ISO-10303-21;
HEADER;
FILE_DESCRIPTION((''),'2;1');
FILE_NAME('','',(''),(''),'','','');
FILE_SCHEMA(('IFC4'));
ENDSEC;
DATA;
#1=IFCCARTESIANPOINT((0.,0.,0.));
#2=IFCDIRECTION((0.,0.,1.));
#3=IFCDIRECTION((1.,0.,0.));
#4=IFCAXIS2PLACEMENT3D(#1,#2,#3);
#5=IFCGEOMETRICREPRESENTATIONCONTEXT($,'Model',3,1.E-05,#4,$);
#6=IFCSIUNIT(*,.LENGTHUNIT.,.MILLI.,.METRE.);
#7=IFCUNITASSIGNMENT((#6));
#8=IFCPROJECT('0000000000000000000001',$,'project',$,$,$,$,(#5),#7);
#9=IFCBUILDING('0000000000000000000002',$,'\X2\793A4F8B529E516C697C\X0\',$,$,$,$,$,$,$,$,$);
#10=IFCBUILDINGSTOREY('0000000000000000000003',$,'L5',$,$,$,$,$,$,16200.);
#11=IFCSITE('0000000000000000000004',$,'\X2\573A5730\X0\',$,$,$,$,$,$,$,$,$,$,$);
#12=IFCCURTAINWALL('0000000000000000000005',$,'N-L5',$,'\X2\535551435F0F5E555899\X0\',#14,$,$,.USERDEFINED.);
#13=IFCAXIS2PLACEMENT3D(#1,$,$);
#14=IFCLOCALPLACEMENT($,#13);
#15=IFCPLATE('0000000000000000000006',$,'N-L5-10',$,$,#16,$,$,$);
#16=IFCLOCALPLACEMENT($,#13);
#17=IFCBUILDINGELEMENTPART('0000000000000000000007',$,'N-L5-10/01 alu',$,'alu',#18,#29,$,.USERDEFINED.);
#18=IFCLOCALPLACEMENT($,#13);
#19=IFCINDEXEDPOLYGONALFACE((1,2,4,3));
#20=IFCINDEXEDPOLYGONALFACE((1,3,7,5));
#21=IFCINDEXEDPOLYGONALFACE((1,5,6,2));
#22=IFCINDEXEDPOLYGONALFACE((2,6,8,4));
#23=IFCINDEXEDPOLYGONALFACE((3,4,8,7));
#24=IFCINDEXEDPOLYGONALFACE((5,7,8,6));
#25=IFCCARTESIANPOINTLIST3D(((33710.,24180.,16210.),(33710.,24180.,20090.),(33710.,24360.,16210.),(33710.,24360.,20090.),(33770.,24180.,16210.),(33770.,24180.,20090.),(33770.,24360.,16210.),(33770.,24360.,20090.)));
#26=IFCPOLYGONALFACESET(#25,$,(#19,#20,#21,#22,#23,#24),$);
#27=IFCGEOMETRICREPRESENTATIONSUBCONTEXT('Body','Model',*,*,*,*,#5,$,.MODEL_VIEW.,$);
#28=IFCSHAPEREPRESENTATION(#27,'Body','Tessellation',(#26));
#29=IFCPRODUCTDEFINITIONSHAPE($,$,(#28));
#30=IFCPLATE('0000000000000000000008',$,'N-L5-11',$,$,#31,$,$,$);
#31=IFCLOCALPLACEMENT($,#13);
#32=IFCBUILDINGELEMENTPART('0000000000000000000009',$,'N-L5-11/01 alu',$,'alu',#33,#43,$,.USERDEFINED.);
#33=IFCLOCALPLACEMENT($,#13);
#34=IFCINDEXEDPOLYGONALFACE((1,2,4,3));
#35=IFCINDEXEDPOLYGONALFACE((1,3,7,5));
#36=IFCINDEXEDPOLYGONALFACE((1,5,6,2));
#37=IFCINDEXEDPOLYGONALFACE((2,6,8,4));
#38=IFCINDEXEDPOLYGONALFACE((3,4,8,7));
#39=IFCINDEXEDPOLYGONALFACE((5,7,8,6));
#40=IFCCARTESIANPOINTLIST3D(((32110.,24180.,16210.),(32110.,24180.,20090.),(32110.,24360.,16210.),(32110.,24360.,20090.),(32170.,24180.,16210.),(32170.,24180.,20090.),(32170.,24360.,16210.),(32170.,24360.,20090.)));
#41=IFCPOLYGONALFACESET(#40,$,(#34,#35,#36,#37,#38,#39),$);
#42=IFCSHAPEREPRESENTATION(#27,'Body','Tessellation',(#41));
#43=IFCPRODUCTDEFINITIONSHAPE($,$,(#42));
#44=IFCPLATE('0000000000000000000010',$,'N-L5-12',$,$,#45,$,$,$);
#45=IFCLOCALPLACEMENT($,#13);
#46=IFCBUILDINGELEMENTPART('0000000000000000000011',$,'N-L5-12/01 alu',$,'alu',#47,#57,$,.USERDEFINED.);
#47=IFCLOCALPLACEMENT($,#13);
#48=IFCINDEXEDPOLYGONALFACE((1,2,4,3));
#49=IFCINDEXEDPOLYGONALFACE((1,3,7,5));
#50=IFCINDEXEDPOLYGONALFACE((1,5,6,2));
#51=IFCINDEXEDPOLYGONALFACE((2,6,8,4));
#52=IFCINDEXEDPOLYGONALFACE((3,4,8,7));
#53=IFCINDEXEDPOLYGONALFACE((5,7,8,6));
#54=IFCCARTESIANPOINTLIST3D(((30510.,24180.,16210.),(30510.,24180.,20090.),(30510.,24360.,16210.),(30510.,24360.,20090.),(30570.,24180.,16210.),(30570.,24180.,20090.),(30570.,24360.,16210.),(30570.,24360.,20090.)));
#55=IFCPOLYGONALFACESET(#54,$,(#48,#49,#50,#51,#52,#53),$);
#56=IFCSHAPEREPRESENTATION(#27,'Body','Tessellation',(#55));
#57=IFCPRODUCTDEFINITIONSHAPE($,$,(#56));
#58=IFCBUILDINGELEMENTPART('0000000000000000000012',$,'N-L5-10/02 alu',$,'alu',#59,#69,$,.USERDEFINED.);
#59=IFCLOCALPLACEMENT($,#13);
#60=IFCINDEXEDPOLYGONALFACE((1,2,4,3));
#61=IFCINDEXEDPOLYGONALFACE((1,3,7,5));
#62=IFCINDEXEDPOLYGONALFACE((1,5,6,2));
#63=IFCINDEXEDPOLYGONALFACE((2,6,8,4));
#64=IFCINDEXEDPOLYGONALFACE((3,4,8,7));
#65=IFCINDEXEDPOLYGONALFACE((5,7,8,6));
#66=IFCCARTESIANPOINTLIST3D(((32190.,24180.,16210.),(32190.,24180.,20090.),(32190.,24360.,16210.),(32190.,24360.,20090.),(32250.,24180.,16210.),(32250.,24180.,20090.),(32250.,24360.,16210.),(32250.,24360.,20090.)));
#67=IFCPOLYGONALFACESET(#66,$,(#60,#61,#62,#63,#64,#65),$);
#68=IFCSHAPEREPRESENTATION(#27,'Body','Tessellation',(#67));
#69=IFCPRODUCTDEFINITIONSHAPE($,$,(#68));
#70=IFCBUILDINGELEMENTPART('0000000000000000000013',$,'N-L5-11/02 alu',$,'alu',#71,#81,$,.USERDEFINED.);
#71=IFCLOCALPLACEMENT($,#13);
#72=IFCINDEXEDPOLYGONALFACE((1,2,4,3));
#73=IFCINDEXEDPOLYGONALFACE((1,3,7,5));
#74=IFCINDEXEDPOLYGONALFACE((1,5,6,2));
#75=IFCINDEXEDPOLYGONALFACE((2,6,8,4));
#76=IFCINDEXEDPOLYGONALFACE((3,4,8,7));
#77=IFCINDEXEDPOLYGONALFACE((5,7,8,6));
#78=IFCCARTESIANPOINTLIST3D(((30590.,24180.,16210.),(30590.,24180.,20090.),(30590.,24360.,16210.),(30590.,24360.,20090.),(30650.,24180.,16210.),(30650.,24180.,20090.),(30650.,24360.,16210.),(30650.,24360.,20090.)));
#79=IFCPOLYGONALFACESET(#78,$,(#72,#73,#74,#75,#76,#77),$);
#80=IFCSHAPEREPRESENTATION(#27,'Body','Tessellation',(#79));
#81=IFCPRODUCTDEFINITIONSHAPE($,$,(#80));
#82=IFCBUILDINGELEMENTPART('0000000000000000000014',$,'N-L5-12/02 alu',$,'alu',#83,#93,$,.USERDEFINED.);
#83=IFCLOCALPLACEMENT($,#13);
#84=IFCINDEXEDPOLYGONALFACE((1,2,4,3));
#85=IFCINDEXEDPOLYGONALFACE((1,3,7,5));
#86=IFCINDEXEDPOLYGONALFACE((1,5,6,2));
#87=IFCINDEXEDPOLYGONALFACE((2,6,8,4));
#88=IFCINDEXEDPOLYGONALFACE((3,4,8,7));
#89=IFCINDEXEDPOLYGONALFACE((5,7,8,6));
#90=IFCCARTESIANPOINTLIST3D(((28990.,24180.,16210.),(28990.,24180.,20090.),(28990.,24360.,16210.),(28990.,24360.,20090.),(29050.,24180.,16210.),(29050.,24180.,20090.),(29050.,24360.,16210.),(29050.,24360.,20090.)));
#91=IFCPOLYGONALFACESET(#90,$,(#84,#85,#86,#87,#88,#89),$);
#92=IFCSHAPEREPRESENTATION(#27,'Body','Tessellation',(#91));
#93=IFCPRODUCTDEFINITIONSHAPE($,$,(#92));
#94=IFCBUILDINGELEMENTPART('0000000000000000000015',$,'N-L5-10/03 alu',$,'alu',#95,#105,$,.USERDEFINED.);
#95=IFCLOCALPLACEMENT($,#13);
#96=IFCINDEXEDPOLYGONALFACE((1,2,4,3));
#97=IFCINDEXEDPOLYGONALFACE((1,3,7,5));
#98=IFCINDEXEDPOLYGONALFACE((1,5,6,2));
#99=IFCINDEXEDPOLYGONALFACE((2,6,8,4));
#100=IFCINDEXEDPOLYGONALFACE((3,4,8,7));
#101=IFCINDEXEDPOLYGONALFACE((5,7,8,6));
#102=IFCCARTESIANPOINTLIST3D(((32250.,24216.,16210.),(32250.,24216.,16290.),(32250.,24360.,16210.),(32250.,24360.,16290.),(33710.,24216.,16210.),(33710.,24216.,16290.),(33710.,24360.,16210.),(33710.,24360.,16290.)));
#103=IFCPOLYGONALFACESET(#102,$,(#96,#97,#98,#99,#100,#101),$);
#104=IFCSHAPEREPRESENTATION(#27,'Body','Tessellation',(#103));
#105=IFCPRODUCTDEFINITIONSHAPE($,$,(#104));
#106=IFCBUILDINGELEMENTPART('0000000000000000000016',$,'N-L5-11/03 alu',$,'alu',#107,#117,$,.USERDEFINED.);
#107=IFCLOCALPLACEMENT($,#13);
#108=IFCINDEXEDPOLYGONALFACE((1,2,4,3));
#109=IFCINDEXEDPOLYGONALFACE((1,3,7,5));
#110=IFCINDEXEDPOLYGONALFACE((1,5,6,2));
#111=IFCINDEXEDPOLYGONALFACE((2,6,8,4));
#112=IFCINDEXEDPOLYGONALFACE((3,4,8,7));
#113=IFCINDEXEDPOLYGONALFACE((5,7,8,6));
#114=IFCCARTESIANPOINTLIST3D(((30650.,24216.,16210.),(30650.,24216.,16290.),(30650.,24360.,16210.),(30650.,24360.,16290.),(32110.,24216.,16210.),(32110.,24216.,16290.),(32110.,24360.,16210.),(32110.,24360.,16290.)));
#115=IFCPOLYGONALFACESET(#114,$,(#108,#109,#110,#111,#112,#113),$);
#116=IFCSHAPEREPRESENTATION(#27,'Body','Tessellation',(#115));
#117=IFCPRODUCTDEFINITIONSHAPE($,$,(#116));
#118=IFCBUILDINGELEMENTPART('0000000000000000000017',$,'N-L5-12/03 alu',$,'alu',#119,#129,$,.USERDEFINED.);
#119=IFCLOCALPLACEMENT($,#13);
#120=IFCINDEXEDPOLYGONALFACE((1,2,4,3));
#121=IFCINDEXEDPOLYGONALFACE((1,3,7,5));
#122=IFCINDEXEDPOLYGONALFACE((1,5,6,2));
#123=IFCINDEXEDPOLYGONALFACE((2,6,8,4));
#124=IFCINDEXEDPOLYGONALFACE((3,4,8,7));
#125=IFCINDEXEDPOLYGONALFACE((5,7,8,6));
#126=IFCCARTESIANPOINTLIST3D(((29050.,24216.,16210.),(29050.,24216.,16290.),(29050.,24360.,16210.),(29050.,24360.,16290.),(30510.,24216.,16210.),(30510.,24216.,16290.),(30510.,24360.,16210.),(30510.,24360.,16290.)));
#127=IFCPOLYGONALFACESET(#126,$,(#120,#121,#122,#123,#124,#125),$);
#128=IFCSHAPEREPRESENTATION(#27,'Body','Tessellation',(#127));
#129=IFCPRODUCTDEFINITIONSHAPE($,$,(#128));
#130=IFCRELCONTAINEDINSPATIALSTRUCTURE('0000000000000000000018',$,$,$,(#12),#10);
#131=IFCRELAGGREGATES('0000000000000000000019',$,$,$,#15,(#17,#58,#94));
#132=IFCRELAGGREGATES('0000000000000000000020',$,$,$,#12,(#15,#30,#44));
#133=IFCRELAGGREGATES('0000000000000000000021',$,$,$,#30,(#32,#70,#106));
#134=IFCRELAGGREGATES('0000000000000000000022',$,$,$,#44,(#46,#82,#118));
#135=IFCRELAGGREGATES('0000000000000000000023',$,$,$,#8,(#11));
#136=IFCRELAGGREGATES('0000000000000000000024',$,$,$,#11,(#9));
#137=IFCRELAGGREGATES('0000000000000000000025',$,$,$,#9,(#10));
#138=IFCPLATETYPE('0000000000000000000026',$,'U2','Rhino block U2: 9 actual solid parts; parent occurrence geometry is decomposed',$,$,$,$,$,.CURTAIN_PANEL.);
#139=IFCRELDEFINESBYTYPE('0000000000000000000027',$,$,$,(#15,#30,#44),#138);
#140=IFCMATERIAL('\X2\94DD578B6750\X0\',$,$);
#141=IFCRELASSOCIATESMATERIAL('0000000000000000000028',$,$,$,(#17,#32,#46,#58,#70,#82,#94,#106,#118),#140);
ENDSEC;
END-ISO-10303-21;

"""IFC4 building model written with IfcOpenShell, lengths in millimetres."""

from ifc_helpers import new_model, si_unit, frame, frame_2d, origin, origin_with_axes, place, context, subcontext, project, spatial, rectangle, extrude, source, transform, mapped, material, type_object, element, aggregate, save


model = new_model("IFC4")

# Units and contexts
model_context = context("Model", 3, precision=1e-05, world=origin_with_axes())
body_context = subcontext(model_context, "Body", "Model", "MODEL_VIEW")
ifc_project = project(units=[si_unit("LENGTHUNIT", "METRE", prefix="MILLI")], contexts=[model_context])

# Site, building, storey
site = spatial("IfcSite", under=ifc_project, Name="场地")
building = spatial("IfcBuilding", under=site, Name="示例办公楼")
storey = spatial("IfcBuildingStorey", under=building, Name="L5", Elevation=16200.0)

# Curtain wall, plates, building element parts
curtain_wall = element("IfcCurtainWall", 1, inside=storey, Name="N-L5", ObjectType="单元式幕墙", PredefinedType="USERDEFINED")
plate_type = type_object("IfcPlateType", Name="U2", Description="Rhino block U2: 9 actual solid parts; parent occurrence geometry is decomposed", PredefinedType="CURTAIN_PANEL")
plate_1_placement = place(None, frame((33770.0, 24360.0, 16210.0), z_axis=(0.0, 0.0, 1.0), x_axis=(-1.0, 0.0, 0.0)))
plate_1 = element("IfcPlate", 2, at=plate_1_placement, type_object=plate_type, Name="N-L5-10")
ifc_material_1 = material(Name="铝型材")
shared_shape_1 = source(origin(), body_context, "Body", "SweptSolid", [
    extrude(rectangle(XDim=60.0, YDim=180.0, at=frame_2d((30.0, 90.0))), origin(), (0.0, 0.0, 1.0), 3880.0),
])
building_element_part_1_placement = place(plate_1_placement, origin())
building_element_part_1 = element("IfcBuildingElementPart", 3, at=building_element_part_1_placement, material=ifc_material_1, Name="N-L5-10/01 alu", ObjectType="alu", PredefinedType="USERDEFINED", context=body_context, shape_type="MappedRepresentation", body=[
    mapped(shared_shape_1, transform((0.0, 0.0, 0.0))),
])
plate_2_placement = place(None, frame((32170.0, 24360.0, 16210.0), z_axis=(0.0, 0.0, 1.0), x_axis=(-1.0, 0.0, 0.0)))
plate_2 = element("IfcPlate", 4, at=plate_2_placement, type_object=plate_type, Name="N-L5-11")
building_element_part_2_placement = place(plate_2_placement, origin())
building_element_part_2 = element("IfcBuildingElementPart", 5, at=building_element_part_2_placement, material=ifc_material_1, Name="N-L5-11/01 alu", ObjectType="alu", PredefinedType="USERDEFINED", context=body_context, shape_type="MappedRepresentation", body=[
    mapped(shared_shape_1, transform((0.0, 0.0, 0.0))),
])
plate_3_placement = place(None, frame((30570.0, 24360.0, 16210.0), z_axis=(0.0, 0.0, 1.0), x_axis=(-1.0, 0.0, 0.0)))
plate_3 = element("IfcPlate", 6, at=plate_3_placement, type_object=plate_type, Name="N-L5-12")
building_element_part_3_placement = place(plate_3_placement, origin())
building_element_part_3 = element("IfcBuildingElementPart", 7, at=building_element_part_3_placement, material=ifc_material_1, Name="N-L5-12/01 alu", ObjectType="alu", PredefinedType="USERDEFINED", context=body_context, shape_type="MappedRepresentation", body=[
    mapped(shared_shape_1, transform((0.0, 0.0, 0.0))),
])
shared_shape_2 = source(origin(), body_context, "Body", "SweptSolid", [
    extrude(rectangle(XDim=60.0, YDim=180.0, at=frame_2d((1550.0, 90.0))), origin(), (0.0, 0.0, 1.0), 3880.0),
])
building_element_part_4_placement = place(plate_1_placement, origin())
building_element_part_4 = element("IfcBuildingElementPart", 8, at=building_element_part_4_placement, material=ifc_material_1, Name="N-L5-10/02 alu", ObjectType="alu", PredefinedType="USERDEFINED", context=body_context, shape_type="MappedRepresentation", body=[
    mapped(shared_shape_2, transform((0.0, 0.0, 0.0))),
])
building_element_part_5_placement = place(plate_2_placement, origin())
building_element_part_5 = element("IfcBuildingElementPart", 9, at=building_element_part_5_placement, material=ifc_material_1, Name="N-L5-11/02 alu", ObjectType="alu", PredefinedType="USERDEFINED", context=body_context, shape_type="MappedRepresentation", body=[
    mapped(shared_shape_2, transform((0.0, 0.0, 0.0))),
])
building_element_part_6_placement = place(plate_3_placement, origin())
building_element_part_6 = element("IfcBuildingElementPart", 10, at=building_element_part_6_placement, material=ifc_material_1, Name="N-L5-12/02 alu", ObjectType="alu", PredefinedType="USERDEFINED", context=body_context, shape_type="MappedRepresentation", body=[
    mapped(shared_shape_2, transform((0.0, 0.0, 0.0))),
])
shared_shape_3 = source(origin(), body_context, "Body", "SweptSolid", [
    extrude(rectangle(XDim=1460.0, YDim=144.0, at=frame_2d((790.0, 72.0))), origin(), (0.0, 0.0, 1.0), 80.0),
])
building_element_part_7_placement = place(plate_1_placement, origin())
building_element_part_7 = element("IfcBuildingElementPart", 11, at=building_element_part_7_placement, material=ifc_material_1, Name="N-L5-10/03 alu", ObjectType="alu", PredefinedType="USERDEFINED", context=body_context, shape_type="MappedRepresentation", body=[
    mapped(shared_shape_3, transform((0.0, 0.0, 0.0))),
])
building_element_part_8_placement = place(plate_2_placement, origin())
building_element_part_8 = element("IfcBuildingElementPart", 12, at=building_element_part_8_placement, material=ifc_material_1, Name="N-L5-11/03 alu", ObjectType="alu", PredefinedType="USERDEFINED", context=body_context, shape_type="MappedRepresentation", body=[
    mapped(shared_shape_3, transform((0.0, 0.0, 0.0))),
])
building_element_part_9_placement = place(plate_3_placement, origin())
building_element_part_9 = element("IfcBuildingElementPart", 13, at=building_element_part_9_placement, material=ifc_material_1, Name="N-L5-12/03 alu", ObjectType="alu", PredefinedType="USERDEFINED", context=body_context, shape_type="MappedRepresentation", body=[
    mapped(shared_shape_3, transform((0.0, 0.0, 0.0))),
])
aggregate(plate_1, [building_element_part_1, building_element_part_4, building_element_part_7])
aggregate(curtain_wall, [plate_1, plate_2, plate_3])
aggregate(plate_2, [building_element_part_2, building_element_part_5, building_element_part_8])
aggregate(plate_3, [building_element_part_3, building_element_part_6, building_element_part_9])

save(model, "model.ifc")
